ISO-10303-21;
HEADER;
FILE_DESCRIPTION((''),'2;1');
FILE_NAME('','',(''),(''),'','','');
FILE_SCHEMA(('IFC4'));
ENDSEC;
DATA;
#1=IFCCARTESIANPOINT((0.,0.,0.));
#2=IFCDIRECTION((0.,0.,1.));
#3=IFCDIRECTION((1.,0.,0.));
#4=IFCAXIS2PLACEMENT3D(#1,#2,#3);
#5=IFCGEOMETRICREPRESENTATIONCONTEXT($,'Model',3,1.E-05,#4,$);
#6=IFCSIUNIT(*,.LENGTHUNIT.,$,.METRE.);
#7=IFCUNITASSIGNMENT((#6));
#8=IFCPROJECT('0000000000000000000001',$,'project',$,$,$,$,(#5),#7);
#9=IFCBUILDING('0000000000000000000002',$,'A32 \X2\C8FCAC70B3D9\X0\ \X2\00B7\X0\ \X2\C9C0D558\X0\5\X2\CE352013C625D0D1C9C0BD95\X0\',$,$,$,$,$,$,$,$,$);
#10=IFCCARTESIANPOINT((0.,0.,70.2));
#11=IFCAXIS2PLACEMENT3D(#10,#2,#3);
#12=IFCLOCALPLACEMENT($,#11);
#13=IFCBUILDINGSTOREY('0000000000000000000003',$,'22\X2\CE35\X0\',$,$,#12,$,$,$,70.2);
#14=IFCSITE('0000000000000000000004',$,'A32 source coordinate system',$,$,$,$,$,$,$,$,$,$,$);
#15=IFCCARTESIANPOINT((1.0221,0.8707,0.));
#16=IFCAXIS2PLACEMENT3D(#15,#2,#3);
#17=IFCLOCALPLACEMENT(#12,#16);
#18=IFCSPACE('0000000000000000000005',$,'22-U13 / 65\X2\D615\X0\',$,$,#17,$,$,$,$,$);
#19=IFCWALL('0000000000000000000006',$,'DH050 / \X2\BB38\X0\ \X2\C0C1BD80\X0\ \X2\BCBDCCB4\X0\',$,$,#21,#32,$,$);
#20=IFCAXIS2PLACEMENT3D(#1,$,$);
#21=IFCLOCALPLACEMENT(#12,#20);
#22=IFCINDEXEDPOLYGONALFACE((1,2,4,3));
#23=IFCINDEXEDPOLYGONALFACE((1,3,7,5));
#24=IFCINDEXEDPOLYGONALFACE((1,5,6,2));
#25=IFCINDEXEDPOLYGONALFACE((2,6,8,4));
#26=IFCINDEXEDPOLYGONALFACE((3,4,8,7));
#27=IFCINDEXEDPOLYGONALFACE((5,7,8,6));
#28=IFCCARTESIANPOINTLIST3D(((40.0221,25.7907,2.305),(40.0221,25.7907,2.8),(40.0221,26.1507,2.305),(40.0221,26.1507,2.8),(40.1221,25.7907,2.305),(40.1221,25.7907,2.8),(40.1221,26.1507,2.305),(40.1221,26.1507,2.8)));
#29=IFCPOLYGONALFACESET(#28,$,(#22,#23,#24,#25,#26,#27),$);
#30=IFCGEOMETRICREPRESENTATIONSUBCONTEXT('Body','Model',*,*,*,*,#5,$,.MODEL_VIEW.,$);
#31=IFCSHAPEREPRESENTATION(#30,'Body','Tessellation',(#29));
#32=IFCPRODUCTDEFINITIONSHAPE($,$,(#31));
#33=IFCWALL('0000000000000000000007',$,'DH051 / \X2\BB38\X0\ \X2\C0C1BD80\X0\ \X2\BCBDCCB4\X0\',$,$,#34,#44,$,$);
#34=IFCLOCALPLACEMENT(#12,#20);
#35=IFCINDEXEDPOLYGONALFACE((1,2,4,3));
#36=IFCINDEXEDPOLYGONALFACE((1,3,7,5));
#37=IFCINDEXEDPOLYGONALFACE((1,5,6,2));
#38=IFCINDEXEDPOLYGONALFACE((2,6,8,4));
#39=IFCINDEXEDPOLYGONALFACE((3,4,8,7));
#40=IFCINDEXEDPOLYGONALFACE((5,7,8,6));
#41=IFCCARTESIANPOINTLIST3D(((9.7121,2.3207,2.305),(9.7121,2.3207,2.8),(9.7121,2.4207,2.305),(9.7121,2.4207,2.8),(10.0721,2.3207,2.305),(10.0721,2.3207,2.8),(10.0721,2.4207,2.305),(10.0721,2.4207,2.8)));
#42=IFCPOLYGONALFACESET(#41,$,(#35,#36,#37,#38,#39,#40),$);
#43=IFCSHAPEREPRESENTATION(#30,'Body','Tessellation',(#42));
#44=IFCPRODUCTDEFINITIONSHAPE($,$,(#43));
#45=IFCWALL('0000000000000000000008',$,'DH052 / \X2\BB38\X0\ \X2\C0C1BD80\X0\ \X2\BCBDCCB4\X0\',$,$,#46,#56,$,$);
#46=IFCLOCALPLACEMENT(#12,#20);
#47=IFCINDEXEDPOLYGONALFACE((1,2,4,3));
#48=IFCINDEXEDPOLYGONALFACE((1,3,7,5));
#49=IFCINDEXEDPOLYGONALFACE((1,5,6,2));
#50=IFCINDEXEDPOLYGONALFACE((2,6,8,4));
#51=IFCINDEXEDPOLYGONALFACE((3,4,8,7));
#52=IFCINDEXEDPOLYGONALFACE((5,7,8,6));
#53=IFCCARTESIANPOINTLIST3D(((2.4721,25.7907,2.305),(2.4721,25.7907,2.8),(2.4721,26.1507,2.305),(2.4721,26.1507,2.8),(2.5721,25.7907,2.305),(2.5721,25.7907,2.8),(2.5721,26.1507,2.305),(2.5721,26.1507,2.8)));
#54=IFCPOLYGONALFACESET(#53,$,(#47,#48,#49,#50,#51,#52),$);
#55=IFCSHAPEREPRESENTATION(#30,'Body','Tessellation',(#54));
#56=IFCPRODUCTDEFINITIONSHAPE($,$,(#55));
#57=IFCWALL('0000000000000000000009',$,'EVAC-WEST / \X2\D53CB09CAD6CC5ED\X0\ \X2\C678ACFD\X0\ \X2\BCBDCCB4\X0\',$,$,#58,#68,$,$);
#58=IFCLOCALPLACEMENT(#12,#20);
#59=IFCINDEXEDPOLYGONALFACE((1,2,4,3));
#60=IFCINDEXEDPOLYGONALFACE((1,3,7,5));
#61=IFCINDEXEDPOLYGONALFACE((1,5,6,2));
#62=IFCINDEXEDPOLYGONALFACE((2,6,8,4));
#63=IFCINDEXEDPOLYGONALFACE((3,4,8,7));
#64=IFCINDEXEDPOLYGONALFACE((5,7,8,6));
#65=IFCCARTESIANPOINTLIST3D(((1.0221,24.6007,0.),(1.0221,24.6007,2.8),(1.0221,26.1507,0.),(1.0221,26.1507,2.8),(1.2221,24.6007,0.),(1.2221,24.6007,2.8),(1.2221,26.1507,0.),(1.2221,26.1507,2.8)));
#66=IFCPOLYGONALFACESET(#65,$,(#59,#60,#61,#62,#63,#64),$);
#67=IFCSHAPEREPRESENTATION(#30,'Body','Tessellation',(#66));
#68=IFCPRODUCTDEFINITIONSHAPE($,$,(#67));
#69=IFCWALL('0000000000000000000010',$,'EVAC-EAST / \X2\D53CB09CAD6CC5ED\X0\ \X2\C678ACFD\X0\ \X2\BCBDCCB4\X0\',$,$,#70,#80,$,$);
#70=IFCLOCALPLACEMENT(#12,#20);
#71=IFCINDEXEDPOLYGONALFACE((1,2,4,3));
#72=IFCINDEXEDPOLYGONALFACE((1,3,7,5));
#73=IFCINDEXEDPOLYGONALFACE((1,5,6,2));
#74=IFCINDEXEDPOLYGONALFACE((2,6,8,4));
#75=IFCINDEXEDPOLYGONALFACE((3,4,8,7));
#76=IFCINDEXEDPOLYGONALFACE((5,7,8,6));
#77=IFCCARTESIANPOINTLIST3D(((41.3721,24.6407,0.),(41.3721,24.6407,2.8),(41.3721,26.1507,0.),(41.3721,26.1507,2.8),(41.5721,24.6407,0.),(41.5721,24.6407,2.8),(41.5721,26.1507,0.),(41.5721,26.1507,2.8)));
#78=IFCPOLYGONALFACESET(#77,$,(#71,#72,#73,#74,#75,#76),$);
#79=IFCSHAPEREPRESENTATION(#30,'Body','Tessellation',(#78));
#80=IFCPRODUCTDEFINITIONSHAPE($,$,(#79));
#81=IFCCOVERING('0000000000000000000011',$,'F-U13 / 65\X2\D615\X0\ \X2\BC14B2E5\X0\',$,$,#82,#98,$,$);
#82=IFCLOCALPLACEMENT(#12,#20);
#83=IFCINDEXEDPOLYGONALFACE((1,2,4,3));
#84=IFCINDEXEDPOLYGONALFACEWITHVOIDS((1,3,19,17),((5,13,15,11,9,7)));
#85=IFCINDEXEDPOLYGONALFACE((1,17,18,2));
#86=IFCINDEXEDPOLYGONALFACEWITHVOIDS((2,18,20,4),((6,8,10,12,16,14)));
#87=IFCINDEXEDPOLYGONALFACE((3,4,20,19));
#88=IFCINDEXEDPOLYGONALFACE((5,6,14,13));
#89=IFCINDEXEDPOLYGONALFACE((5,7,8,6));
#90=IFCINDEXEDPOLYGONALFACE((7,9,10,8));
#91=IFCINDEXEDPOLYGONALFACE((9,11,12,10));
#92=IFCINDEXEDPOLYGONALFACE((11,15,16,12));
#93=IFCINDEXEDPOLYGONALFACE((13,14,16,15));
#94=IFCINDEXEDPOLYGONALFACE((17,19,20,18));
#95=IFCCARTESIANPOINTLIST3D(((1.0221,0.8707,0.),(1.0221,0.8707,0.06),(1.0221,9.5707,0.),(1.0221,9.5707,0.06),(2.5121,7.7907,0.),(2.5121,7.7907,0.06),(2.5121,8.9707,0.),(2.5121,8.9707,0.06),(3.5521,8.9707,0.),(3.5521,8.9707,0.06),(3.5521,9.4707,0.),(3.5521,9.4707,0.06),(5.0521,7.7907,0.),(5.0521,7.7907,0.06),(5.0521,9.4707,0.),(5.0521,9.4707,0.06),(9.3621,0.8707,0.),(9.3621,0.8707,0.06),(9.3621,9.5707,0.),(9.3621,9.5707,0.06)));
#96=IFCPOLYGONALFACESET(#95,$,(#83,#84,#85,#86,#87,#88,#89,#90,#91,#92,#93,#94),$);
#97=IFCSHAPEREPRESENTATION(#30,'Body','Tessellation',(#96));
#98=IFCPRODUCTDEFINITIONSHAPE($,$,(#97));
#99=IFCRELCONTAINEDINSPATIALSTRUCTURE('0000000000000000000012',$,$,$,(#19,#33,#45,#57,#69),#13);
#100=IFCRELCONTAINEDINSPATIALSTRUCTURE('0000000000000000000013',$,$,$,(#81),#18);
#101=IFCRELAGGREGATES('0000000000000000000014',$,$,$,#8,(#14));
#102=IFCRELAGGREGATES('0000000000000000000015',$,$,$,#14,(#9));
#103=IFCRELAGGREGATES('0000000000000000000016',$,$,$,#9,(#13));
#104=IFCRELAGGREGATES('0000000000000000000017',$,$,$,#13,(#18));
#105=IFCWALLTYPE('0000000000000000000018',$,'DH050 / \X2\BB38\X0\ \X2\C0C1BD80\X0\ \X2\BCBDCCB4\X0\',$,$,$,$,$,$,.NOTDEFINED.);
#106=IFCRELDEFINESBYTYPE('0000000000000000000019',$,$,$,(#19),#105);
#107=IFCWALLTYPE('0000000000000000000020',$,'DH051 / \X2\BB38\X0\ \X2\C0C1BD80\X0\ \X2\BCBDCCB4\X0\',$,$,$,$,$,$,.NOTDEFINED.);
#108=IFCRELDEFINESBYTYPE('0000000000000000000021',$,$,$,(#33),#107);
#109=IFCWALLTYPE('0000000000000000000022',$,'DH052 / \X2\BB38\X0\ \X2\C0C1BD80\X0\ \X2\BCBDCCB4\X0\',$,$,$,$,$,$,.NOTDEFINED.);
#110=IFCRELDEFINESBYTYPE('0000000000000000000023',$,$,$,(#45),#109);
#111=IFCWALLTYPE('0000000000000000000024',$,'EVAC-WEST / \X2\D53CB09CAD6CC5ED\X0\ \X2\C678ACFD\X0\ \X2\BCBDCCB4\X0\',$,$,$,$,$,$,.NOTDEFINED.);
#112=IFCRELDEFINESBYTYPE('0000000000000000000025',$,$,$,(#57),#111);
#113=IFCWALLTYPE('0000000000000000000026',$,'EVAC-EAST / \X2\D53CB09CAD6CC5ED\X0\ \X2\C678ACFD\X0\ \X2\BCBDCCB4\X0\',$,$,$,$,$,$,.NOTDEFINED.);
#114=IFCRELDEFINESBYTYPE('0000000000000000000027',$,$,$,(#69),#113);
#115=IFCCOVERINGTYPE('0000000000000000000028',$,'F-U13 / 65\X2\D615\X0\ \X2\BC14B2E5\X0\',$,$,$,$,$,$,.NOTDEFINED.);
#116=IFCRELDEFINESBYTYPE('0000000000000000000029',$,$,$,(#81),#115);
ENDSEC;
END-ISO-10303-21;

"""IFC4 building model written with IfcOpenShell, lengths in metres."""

from ifc_helpers import new_model, si_unit, frame, origin, origin_with_axes, place, context, subcontext, project, spatial, polyline, outline, extrude, source, transform, mapped, type_object, type_shapes, element, save


model = new_model("IFC4")

# Units and contexts
model_context = context("Model", 3, precision=1e-05, world=origin_with_axes())
body_context = subcontext(model_context, "Body", "Model", "MODEL_VIEW")
ifc_project = project(units=[si_unit("LENGTHUNIT", "METRE")], contexts=[model_context])

# Site, building, storey
site = spatial("IfcSite", under=ifc_project, Name="A32 source coordinate system")
building = spatial("IfcBuilding", under=site, Name="A32 주거동 · 지하5층–옥탑지붕")
storey_placement = place(None, frame((0.0, 0.0, 70.2), z_axis=(0.0, 0.0, 1.0), x_axis=(1.0, 0.0, 0.0)))
storey = spatial("IfcBuildingStorey", under=building, at=storey_placement, Name="22층", Elevation=70.2)

# Walls
wall_type_1 = type_object("IfcWallType", Name="DH050 / 문 상부 벽체", PredefinedType="NOTDEFINED")
shared_shape_1 = source(origin(), body_context, "Body", "SweptSolid", [
    extrude(outline(polyline([(40.0221, 25.7907), (40.0221, 26.1507), (40.1221, 26.1507), (40.1221, 25.7907), (40.0221, 25.7907)])), frame((0.0, 0.0, 2.305)), (0.0, 0.0, 1.0), 0.495),
])
type_shapes(wall_type_1, [shared_shape_1])
wall_1_placement = place(storey_placement, origin_with_axes())
element("IfcWall", 1, at=wall_1_placement, inside=storey, type_object=wall_type_1, Name="DH050 / 문 상부 벽체", context=body_context, shape_type="MappedRepresentation", body=[
    mapped(shared_shape_1, transform((0.0, 0.0, 0.0), scale=1.0)),
])
wall_type_2 = type_object("IfcWallType", Name="DH051 / 문 상부 벽체", PredefinedType="NOTDEFINED")
shared_shape_2 = source(origin(), body_context, "Body", "SweptSolid", [
    extrude(outline(polyline([(10.0721, 2.3207), (9.7121, 2.3207), (9.7121, 2.4207), (10.0721, 2.4207), (10.0721, 2.3207)])), frame((0.0, 0.0, 2.305)), (0.0, 0.0, 1.0), 0.495),
])
type_shapes(wall_type_2, [shared_shape_2])
wall_2_placement = place(storey_placement, origin_with_axes())
element("IfcWall", 2, at=wall_2_placement, inside=storey, type_object=wall_type_2, Name="DH051 / 문 상부 벽체", context=body_context, shape_type="MappedRepresentation", body=[
    mapped(shared_shape_2, transform((0.0, 0.0, 0.0), scale=1.0)),
])
wall_type_3 = type_object("IfcWallType", Name="DH052 / 문 상부 벽체", PredefinedType="NOTDEFINED")
shared_shape_3 = source(origin(), body_context, "Body", "SweptSolid", [
    extrude(outline(polyline([(2.5721, 25.7907), (2.4721, 25.7907), (2.4721, 26.1507), (2.5721, 26.1507), (2.5721, 25.7907)])), frame((0.0, 0.0, 2.305)), (0.0, 0.0, 1.0), 0.495),
])
type_shapes(wall_type_3, [shared_shape_3])
wall_3_placement = place(storey_placement, origin_with_axes())
element("IfcWall", 3, at=wall_3_placement, inside=storey, type_object=wall_type_3, Name="DH052 / 문 상부 벽체", context=body_context, shape_type="MappedRepresentation", body=[
    mapped(shared_shape_3, transform((0.0, 0.0, 0.0), scale=1.0)),
])
wall_type_4 = type_object("IfcWallType", Name="EVAC-WEST / 피난구역 외곽 벽체", PredefinedType="NOTDEFINED")
shared_shape_4 = source(origin(), body_context, "Body", "SweptSolid", [
    extrude(outline(polyline([(1.2221, 24.6007), (1.0221, 24.6007), (1.0221, 26.1507), (1.2221, 26.1507), (1.2221, 24.6007)])), origin(), (0.0, 0.0, 1.0), 2.8),
])
type_shapes(wall_type_4, [shared_shape_4])
wall_4_placement = place(storey_placement, origin_with_axes())
element("IfcWall", 4, at=wall_4_placement, inside=storey, type_object=wall_type_4, Name="EVAC-WEST / 피난구역 외곽 벽체", context=body_context, shape_type="MappedRepresentation", body=[
    mapped(shared_shape_4, transform((0.0, 0.0, 0.0), scale=1.0)),
])
wall_type_5 = type_object("IfcWallType", Name="EVAC-EAST / 피난구역 외곽 벽체", PredefinedType="NOTDEFINED")
shared_shape_5 = source(origin(), body_context, "Body", "SweptSolid", [
    extrude(outline(polyline([(41.5721, 26.1507), (41.5721, 24.6407), (41.3721, 24.6407), (41.3721, 26.1507), (41.5721, 26.1507)])), origin(), (0.0, 0.0, 1.0), 2.8),
])
type_shapes(wall_type_5, [shared_shape_5])
wall_5_placement = place(storey_placement, origin_with_axes())
element("IfcWall", 5, at=wall_5_placement, inside=storey, type_object=wall_type_5, Name="EVAC-EAST / 피난구역 외곽 벽체", context=body_context, shape_type="MappedRepresentation", body=[
    mapped(shared_shape_5, transform((0.0, 0.0, 0.0), scale=1.0)),
])

# Shared definitions
space_placement = place(storey_placement, frame((1.0221, 0.8707, 0.0), z_axis=(0.0, 0.0, 1.0), x_axis=(1.0, 0.0, 0.0)))
space = spatial("IfcSpace", under=storey, at=space_placement, Name="22-U13 / 65형")

# Covering
covering_type_1 = type_object("IfcCoveringType", Name="F-U13 / 65형 바닥", PredefinedType="NOTDEFINED")
shared_shape_6 = source(origin(), body_context, "Body", "SweptSolid", [
    extrude(outline(polyline([(0.0, 0.0), (0.0, 8.7), (8.34, 8.7), (8.34, 0.0), (0.0, 0.0)]), holes=[polyline([(2.53, 8.1), (1.49, 8.1), (1.49, 6.92), (4.03, 6.92), (4.03, 8.6), (2.53, 8.6), (2.53, 8.1)])]), origin(), (0.0, 0.0, 1.0), 0.06),
])
type_shapes(covering_type_1, [shared_shape_6])
covering_1_placement = place(space_placement, origin_with_axes())
element("IfcCovering", 6, at=covering_1_placement, inside=space, type_object=covering_type_1, Name="F-U13 / 65형 바닥", context=body_context, shape_type="MappedRepresentation", body=[
    mapped(shared_shape_6, transform((0.0, 0.0, 0.0), scale=1.0)),
])

save(model, "model.ifc")
